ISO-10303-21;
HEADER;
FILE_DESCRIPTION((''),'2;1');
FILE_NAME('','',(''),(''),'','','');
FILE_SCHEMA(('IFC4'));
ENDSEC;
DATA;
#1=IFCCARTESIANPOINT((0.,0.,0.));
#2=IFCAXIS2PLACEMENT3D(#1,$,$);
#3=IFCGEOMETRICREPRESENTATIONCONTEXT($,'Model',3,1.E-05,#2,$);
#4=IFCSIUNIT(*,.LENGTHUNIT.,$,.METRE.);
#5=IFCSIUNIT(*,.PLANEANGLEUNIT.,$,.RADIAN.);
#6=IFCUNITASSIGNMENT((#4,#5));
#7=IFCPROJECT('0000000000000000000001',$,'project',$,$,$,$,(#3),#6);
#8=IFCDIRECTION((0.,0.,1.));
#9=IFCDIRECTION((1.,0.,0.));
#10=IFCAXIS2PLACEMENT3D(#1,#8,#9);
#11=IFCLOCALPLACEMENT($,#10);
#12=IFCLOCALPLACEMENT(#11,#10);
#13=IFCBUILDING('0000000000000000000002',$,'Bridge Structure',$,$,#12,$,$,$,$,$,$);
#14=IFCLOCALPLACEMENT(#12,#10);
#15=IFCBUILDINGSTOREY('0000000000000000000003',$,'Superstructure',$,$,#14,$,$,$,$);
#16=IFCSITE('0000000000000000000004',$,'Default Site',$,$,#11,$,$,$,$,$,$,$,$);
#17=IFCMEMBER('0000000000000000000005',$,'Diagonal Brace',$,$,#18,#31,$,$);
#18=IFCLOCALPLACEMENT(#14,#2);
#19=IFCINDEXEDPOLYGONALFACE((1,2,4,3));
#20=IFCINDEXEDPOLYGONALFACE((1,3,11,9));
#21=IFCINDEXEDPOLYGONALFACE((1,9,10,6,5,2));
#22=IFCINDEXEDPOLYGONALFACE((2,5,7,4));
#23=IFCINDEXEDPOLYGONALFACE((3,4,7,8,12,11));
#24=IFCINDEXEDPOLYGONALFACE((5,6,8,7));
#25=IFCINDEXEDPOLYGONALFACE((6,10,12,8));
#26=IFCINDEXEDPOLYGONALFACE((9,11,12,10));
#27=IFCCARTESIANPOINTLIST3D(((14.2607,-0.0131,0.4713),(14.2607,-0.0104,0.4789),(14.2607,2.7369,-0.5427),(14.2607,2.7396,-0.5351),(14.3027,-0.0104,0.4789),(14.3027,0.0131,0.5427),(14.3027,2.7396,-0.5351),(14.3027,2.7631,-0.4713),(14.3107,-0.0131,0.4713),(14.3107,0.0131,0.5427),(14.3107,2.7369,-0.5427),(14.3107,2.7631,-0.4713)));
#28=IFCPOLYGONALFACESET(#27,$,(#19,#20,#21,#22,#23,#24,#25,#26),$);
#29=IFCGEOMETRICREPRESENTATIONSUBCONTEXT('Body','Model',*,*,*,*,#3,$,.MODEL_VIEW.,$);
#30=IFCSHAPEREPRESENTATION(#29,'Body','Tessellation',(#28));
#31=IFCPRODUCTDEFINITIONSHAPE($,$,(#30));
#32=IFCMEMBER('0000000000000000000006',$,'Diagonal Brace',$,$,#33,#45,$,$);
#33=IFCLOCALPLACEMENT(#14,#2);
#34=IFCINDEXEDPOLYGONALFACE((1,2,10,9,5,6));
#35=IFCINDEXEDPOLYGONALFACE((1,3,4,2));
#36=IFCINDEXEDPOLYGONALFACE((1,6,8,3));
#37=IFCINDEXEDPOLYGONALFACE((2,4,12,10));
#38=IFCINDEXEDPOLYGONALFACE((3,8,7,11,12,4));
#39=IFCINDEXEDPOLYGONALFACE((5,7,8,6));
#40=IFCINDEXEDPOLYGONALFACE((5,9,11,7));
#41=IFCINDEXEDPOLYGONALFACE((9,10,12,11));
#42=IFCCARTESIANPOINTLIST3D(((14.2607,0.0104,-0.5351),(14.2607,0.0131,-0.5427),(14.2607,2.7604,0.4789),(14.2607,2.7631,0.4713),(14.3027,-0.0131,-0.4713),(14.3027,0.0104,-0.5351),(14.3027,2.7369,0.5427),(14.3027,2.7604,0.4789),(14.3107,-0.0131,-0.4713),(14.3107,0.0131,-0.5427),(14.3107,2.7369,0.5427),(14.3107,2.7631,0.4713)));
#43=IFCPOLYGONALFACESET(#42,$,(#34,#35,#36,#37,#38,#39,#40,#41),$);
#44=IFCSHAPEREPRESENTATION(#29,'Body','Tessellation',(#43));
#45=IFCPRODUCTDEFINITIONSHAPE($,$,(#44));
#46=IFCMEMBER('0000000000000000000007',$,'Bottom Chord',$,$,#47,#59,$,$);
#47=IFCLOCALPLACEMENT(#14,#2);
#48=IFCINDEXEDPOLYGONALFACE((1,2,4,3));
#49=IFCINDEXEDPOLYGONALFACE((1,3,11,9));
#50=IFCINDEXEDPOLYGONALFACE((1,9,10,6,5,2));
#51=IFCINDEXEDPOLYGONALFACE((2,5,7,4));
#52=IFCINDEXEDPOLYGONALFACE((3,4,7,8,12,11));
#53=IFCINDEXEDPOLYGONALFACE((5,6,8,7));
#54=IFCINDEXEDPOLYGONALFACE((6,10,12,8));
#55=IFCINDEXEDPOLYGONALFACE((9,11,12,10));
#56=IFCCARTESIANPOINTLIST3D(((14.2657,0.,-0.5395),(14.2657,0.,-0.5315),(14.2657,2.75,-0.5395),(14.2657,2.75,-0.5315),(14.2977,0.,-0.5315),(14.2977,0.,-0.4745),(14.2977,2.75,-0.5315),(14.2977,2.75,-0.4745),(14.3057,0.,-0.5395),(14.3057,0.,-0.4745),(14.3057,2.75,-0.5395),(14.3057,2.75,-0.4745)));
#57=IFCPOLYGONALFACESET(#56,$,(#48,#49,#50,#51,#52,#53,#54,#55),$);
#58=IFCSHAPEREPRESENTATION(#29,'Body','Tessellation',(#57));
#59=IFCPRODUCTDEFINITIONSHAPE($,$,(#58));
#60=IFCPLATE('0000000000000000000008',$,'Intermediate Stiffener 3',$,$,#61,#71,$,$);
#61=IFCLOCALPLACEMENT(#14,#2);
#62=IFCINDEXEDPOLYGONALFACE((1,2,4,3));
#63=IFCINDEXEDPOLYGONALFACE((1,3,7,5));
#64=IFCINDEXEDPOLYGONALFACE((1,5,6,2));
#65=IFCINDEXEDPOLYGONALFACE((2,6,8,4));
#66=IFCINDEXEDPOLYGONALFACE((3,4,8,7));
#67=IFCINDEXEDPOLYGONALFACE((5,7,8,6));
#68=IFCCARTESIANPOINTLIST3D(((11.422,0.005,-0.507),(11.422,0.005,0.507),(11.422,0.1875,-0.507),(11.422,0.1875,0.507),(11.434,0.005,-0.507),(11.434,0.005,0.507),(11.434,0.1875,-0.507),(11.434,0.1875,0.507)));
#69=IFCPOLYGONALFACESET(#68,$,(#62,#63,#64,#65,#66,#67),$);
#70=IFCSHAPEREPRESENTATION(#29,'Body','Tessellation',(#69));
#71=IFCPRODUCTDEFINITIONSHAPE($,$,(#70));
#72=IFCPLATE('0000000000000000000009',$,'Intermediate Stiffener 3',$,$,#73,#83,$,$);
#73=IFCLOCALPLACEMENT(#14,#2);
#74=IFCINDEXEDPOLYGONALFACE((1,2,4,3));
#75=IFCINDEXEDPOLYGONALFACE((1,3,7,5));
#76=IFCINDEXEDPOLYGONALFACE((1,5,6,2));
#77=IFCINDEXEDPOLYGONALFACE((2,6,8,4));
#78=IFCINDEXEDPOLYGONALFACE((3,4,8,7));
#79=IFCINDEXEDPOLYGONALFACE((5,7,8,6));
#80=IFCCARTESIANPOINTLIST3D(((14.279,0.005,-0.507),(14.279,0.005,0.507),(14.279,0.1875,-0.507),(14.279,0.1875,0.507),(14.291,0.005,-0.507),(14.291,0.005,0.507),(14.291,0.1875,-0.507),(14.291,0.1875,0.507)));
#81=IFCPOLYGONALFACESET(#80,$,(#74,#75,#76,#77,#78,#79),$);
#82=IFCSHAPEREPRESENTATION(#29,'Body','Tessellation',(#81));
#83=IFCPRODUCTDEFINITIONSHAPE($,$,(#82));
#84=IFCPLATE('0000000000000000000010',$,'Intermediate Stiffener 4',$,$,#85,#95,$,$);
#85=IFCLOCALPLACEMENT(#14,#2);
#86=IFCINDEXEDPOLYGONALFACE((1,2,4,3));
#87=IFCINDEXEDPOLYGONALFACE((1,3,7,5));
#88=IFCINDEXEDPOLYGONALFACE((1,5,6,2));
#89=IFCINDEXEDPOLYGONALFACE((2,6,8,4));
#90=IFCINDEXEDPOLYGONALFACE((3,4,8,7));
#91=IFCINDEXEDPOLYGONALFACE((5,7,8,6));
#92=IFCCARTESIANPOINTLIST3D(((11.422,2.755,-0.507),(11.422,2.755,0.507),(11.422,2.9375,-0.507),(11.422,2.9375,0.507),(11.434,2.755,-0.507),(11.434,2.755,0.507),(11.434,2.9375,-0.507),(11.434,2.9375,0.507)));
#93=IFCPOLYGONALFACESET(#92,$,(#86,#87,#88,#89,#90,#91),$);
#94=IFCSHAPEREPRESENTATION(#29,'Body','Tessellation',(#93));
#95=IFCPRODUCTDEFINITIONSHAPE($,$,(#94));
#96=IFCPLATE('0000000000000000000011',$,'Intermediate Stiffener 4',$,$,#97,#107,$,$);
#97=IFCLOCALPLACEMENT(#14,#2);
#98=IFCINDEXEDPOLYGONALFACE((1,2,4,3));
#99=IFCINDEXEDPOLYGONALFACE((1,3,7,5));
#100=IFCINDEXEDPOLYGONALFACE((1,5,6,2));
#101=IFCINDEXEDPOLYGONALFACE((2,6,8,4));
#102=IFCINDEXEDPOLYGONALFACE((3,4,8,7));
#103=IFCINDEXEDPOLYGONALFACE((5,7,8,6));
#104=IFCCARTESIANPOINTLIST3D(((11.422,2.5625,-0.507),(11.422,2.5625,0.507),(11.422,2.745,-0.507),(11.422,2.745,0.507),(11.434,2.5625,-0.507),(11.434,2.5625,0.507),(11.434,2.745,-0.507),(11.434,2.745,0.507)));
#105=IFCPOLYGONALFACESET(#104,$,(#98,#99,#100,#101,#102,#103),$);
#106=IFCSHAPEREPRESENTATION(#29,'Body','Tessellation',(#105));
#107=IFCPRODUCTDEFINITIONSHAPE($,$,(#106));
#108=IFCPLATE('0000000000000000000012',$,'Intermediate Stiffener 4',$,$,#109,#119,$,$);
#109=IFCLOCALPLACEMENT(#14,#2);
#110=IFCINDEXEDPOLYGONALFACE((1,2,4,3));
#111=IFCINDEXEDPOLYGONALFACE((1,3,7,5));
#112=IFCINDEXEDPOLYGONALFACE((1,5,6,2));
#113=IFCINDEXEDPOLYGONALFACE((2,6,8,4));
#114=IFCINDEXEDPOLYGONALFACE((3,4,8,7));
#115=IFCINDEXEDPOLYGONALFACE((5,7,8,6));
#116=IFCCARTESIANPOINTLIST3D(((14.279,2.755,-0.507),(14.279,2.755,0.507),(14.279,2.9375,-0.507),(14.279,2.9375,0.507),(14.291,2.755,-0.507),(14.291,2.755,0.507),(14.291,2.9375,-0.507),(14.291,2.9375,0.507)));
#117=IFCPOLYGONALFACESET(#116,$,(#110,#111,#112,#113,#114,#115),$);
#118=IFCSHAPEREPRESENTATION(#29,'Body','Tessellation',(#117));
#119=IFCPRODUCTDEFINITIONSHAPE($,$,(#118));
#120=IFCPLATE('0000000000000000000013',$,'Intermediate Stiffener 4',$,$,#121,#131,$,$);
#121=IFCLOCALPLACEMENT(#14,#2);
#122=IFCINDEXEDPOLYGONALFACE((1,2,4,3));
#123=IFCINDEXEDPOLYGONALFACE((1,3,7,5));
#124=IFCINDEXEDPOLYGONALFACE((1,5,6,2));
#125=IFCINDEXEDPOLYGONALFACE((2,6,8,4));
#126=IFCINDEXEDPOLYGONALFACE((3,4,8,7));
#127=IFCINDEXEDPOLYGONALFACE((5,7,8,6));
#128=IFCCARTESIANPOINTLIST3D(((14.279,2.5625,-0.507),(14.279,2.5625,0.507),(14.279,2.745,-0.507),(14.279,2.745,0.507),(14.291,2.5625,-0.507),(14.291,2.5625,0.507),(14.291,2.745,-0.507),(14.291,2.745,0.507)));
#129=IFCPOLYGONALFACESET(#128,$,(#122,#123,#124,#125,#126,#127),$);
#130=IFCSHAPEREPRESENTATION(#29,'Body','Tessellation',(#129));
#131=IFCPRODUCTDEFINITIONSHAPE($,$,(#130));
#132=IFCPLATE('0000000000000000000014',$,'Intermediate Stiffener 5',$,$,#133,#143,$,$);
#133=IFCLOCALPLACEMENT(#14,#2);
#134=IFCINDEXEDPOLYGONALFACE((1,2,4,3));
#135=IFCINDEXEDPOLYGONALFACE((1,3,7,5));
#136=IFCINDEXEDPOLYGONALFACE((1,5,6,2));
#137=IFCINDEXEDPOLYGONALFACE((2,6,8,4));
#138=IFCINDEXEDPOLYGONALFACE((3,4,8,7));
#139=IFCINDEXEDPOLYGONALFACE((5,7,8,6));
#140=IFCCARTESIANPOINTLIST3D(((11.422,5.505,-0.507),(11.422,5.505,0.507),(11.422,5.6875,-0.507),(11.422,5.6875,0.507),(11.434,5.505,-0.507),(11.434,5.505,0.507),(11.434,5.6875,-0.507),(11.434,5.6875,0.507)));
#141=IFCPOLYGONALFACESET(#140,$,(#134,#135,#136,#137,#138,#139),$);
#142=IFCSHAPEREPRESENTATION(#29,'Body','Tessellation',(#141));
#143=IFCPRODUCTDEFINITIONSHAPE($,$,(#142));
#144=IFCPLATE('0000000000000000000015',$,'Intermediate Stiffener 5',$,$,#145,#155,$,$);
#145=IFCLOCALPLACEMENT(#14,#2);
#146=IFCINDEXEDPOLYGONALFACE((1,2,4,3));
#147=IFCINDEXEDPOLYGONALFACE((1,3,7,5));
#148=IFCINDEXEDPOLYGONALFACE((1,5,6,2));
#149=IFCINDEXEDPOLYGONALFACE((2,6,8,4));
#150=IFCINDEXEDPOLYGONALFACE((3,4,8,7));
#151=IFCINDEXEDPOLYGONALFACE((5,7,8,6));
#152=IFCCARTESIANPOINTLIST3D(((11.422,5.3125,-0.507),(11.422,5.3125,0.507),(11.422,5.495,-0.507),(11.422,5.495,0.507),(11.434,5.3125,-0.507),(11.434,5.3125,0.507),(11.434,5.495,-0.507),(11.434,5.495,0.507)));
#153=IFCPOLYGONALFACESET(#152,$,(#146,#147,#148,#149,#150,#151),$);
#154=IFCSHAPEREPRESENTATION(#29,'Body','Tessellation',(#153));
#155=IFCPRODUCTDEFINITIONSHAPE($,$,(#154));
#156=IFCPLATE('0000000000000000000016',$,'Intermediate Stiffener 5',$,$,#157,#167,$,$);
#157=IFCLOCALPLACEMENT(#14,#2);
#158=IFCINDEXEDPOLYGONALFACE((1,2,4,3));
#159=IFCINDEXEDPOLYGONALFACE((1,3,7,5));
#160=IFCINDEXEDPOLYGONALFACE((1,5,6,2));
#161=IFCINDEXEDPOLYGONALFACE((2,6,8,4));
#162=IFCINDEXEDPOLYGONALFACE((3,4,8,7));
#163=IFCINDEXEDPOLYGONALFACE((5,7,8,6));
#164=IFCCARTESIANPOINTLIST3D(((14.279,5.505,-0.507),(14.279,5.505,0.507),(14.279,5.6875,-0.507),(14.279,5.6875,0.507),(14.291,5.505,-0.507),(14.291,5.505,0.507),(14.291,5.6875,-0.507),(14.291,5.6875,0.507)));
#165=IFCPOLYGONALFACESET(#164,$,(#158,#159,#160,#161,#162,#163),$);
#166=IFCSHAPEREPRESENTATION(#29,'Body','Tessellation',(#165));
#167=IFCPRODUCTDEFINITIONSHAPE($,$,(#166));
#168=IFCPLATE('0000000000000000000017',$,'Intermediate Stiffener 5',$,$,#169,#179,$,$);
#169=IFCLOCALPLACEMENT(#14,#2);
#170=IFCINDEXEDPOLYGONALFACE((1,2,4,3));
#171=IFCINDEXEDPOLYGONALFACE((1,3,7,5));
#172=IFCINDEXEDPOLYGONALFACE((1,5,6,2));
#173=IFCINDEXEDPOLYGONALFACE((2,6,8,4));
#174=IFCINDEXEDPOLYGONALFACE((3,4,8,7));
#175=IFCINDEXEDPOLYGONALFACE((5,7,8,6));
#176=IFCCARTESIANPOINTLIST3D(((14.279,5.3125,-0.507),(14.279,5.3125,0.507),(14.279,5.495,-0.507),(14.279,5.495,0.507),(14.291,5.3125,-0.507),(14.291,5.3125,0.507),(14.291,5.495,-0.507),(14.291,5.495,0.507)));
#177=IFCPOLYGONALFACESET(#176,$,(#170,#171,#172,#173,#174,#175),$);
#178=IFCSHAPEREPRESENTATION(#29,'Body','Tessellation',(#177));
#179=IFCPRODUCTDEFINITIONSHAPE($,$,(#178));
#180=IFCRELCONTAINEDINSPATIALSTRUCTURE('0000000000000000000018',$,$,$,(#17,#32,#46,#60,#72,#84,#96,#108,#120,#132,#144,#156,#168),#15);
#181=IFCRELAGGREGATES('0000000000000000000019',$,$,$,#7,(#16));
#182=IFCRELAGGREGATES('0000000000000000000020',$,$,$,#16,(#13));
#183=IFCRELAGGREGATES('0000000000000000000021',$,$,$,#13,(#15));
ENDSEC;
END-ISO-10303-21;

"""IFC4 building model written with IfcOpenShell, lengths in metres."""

from ifc_helpers import new_model, si_unit, frame, origin, origin_with_axes, origin_2d_with_axis, place, context, subcontext, project, spatial, rectangle, l_section, extrude, element, save


model = new_model("IFC4")

# Units and contexts
model_context = context("Model", 3, precision=1e-05, world=origin())
body_context = subcontext(model_context, "Body", "Model", "MODEL_VIEW")
ifc_project = project(units=[si_unit("LENGTHUNIT", "METRE"), si_unit("PLANEANGLEUNIT", "RADIAN")], contexts=[model_context])

# Site, building, storey
site_placement = place(None, origin_with_axes())
site = spatial("IfcSite", under=ifc_project, at=site_placement, Name="Default Site")
building_placement = place(site_placement, origin_with_axes())
building = spatial("IfcBuilding", under=site, at=building_placement, Name="Bridge Structure")
storey_placement = place(building_placement, origin_with_axes())
storey = spatial("IfcBuildingStorey", under=building, at=storey_placement, Name="Superstructure")

# Members
for number, where, z_axis, x_axis, name in (
    (1, (14.2857, 0.0, 0.507), (0.0, 0.93825, -0.345958), (-1.0, 0.0, 0.0), "Diagonal Brace"),
    (2, (14.2857, 0.0, -0.507), (0.0, 0.93825, 0.345958), (-1.0, 0.0, 0.0), "Diagonal Brace"),
):
    element("IfcMember", number, at=place(storey_placement, frame(where, z_axis=z_axis, x_axis=x_axis)), inside=storey, Name=name, context=body_context, shape_type="SweptSolid", body=[
        extrude(l_section(Depth=0.076, Width=0.05, Thickness=0.008, at=origin_2d_with_axis()), origin_with_axes(), (0.0, 0.0, 1.0), 2.931),
    ])
member_1_placement = place(storey_placement, frame((14.2857, 0.0, -0.507), z_axis=(0.0, 1.0, 0.0), x_axis=(-1.0, 0.0, 0.0)))
element("IfcMember", 3, at=member_1_placement, inside=storey, Name="Bottom Chord", context=body_context, shape_type="SweptSolid", body=[
    extrude(l_section(Depth=0.065, Width=0.04, Thickness=0.008, at=origin_2d_with_axis()), origin_with_axes(), (0.0, 0.0, 1.0), 2.75),
])

# Plates
for number, where, z_axis, x_axis, name in (
    (4, (11.428, 0.0963, -0.507), (0.0, 0.0, 1.0), (1.0, 0.0, 0.0), "Intermediate Stiffener 3"),
    (5, (14.285, 0.0963, -0.507), (0.0, 0.0, 1.0), (1.0, 0.0, 0.0), "Intermediate Stiffener 3"),
    (6, (11.428, 2.8462, -0.507), (0.0, 0.0, 1.0), (1.0, 0.0, 0.0), "Intermediate Stiffener 4"),
    (7, (11.428, 2.6538, -0.507), (0.0, 0.0, 1.0), (1.0, 0.0, 0.0), "Intermediate Stiffener 4"),
    (8, (14.285, 2.8462, -0.507), (0.0, 0.0, 1.0), (1.0, 0.0, 0.0), "Intermediate Stiffener 4"),
    (9, (14.285, 2.6538, -0.507), (0.0, 0.0, 1.0), (1.0, 0.0, 0.0), "Intermediate Stiffener 4"),
    (10, (11.428, 5.5963, -0.507), (0.0, 0.0, 1.0), (1.0, 0.0, 0.0), "Intermediate Stiffener 5"),
    (11, (11.428, 5.4038, -0.507), (0.0, 0.0, 1.0), (1.0, 0.0, 0.0), "Intermediate Stiffener 5"),
    (12, (14.285, 5.5963, -0.507), (0.0, 0.0, 1.0), (1.0, 0.0, 0.0), "Intermediate Stiffener 5"),
    (13, (14.285, 5.4038, -0.507), (0.0, 0.0, 1.0), (1.0, 0.0, 0.0), "Intermediate Stiffener 5"),
):
    element("IfcPlate", number, at=place(storey_placement, frame(where, z_axis=z_axis, x_axis=x_axis)), inside=storey, Name=name, context=body_context, shape_type="SweptSolid", body=[
        extrude(rectangle(XDim=0.012, YDim=0.1825, at=origin_2d_with_axis()), origin_with_axes(), (0.0, 0.0, 1.0), 1.014),
    ])

save(model, "model.ifc")
